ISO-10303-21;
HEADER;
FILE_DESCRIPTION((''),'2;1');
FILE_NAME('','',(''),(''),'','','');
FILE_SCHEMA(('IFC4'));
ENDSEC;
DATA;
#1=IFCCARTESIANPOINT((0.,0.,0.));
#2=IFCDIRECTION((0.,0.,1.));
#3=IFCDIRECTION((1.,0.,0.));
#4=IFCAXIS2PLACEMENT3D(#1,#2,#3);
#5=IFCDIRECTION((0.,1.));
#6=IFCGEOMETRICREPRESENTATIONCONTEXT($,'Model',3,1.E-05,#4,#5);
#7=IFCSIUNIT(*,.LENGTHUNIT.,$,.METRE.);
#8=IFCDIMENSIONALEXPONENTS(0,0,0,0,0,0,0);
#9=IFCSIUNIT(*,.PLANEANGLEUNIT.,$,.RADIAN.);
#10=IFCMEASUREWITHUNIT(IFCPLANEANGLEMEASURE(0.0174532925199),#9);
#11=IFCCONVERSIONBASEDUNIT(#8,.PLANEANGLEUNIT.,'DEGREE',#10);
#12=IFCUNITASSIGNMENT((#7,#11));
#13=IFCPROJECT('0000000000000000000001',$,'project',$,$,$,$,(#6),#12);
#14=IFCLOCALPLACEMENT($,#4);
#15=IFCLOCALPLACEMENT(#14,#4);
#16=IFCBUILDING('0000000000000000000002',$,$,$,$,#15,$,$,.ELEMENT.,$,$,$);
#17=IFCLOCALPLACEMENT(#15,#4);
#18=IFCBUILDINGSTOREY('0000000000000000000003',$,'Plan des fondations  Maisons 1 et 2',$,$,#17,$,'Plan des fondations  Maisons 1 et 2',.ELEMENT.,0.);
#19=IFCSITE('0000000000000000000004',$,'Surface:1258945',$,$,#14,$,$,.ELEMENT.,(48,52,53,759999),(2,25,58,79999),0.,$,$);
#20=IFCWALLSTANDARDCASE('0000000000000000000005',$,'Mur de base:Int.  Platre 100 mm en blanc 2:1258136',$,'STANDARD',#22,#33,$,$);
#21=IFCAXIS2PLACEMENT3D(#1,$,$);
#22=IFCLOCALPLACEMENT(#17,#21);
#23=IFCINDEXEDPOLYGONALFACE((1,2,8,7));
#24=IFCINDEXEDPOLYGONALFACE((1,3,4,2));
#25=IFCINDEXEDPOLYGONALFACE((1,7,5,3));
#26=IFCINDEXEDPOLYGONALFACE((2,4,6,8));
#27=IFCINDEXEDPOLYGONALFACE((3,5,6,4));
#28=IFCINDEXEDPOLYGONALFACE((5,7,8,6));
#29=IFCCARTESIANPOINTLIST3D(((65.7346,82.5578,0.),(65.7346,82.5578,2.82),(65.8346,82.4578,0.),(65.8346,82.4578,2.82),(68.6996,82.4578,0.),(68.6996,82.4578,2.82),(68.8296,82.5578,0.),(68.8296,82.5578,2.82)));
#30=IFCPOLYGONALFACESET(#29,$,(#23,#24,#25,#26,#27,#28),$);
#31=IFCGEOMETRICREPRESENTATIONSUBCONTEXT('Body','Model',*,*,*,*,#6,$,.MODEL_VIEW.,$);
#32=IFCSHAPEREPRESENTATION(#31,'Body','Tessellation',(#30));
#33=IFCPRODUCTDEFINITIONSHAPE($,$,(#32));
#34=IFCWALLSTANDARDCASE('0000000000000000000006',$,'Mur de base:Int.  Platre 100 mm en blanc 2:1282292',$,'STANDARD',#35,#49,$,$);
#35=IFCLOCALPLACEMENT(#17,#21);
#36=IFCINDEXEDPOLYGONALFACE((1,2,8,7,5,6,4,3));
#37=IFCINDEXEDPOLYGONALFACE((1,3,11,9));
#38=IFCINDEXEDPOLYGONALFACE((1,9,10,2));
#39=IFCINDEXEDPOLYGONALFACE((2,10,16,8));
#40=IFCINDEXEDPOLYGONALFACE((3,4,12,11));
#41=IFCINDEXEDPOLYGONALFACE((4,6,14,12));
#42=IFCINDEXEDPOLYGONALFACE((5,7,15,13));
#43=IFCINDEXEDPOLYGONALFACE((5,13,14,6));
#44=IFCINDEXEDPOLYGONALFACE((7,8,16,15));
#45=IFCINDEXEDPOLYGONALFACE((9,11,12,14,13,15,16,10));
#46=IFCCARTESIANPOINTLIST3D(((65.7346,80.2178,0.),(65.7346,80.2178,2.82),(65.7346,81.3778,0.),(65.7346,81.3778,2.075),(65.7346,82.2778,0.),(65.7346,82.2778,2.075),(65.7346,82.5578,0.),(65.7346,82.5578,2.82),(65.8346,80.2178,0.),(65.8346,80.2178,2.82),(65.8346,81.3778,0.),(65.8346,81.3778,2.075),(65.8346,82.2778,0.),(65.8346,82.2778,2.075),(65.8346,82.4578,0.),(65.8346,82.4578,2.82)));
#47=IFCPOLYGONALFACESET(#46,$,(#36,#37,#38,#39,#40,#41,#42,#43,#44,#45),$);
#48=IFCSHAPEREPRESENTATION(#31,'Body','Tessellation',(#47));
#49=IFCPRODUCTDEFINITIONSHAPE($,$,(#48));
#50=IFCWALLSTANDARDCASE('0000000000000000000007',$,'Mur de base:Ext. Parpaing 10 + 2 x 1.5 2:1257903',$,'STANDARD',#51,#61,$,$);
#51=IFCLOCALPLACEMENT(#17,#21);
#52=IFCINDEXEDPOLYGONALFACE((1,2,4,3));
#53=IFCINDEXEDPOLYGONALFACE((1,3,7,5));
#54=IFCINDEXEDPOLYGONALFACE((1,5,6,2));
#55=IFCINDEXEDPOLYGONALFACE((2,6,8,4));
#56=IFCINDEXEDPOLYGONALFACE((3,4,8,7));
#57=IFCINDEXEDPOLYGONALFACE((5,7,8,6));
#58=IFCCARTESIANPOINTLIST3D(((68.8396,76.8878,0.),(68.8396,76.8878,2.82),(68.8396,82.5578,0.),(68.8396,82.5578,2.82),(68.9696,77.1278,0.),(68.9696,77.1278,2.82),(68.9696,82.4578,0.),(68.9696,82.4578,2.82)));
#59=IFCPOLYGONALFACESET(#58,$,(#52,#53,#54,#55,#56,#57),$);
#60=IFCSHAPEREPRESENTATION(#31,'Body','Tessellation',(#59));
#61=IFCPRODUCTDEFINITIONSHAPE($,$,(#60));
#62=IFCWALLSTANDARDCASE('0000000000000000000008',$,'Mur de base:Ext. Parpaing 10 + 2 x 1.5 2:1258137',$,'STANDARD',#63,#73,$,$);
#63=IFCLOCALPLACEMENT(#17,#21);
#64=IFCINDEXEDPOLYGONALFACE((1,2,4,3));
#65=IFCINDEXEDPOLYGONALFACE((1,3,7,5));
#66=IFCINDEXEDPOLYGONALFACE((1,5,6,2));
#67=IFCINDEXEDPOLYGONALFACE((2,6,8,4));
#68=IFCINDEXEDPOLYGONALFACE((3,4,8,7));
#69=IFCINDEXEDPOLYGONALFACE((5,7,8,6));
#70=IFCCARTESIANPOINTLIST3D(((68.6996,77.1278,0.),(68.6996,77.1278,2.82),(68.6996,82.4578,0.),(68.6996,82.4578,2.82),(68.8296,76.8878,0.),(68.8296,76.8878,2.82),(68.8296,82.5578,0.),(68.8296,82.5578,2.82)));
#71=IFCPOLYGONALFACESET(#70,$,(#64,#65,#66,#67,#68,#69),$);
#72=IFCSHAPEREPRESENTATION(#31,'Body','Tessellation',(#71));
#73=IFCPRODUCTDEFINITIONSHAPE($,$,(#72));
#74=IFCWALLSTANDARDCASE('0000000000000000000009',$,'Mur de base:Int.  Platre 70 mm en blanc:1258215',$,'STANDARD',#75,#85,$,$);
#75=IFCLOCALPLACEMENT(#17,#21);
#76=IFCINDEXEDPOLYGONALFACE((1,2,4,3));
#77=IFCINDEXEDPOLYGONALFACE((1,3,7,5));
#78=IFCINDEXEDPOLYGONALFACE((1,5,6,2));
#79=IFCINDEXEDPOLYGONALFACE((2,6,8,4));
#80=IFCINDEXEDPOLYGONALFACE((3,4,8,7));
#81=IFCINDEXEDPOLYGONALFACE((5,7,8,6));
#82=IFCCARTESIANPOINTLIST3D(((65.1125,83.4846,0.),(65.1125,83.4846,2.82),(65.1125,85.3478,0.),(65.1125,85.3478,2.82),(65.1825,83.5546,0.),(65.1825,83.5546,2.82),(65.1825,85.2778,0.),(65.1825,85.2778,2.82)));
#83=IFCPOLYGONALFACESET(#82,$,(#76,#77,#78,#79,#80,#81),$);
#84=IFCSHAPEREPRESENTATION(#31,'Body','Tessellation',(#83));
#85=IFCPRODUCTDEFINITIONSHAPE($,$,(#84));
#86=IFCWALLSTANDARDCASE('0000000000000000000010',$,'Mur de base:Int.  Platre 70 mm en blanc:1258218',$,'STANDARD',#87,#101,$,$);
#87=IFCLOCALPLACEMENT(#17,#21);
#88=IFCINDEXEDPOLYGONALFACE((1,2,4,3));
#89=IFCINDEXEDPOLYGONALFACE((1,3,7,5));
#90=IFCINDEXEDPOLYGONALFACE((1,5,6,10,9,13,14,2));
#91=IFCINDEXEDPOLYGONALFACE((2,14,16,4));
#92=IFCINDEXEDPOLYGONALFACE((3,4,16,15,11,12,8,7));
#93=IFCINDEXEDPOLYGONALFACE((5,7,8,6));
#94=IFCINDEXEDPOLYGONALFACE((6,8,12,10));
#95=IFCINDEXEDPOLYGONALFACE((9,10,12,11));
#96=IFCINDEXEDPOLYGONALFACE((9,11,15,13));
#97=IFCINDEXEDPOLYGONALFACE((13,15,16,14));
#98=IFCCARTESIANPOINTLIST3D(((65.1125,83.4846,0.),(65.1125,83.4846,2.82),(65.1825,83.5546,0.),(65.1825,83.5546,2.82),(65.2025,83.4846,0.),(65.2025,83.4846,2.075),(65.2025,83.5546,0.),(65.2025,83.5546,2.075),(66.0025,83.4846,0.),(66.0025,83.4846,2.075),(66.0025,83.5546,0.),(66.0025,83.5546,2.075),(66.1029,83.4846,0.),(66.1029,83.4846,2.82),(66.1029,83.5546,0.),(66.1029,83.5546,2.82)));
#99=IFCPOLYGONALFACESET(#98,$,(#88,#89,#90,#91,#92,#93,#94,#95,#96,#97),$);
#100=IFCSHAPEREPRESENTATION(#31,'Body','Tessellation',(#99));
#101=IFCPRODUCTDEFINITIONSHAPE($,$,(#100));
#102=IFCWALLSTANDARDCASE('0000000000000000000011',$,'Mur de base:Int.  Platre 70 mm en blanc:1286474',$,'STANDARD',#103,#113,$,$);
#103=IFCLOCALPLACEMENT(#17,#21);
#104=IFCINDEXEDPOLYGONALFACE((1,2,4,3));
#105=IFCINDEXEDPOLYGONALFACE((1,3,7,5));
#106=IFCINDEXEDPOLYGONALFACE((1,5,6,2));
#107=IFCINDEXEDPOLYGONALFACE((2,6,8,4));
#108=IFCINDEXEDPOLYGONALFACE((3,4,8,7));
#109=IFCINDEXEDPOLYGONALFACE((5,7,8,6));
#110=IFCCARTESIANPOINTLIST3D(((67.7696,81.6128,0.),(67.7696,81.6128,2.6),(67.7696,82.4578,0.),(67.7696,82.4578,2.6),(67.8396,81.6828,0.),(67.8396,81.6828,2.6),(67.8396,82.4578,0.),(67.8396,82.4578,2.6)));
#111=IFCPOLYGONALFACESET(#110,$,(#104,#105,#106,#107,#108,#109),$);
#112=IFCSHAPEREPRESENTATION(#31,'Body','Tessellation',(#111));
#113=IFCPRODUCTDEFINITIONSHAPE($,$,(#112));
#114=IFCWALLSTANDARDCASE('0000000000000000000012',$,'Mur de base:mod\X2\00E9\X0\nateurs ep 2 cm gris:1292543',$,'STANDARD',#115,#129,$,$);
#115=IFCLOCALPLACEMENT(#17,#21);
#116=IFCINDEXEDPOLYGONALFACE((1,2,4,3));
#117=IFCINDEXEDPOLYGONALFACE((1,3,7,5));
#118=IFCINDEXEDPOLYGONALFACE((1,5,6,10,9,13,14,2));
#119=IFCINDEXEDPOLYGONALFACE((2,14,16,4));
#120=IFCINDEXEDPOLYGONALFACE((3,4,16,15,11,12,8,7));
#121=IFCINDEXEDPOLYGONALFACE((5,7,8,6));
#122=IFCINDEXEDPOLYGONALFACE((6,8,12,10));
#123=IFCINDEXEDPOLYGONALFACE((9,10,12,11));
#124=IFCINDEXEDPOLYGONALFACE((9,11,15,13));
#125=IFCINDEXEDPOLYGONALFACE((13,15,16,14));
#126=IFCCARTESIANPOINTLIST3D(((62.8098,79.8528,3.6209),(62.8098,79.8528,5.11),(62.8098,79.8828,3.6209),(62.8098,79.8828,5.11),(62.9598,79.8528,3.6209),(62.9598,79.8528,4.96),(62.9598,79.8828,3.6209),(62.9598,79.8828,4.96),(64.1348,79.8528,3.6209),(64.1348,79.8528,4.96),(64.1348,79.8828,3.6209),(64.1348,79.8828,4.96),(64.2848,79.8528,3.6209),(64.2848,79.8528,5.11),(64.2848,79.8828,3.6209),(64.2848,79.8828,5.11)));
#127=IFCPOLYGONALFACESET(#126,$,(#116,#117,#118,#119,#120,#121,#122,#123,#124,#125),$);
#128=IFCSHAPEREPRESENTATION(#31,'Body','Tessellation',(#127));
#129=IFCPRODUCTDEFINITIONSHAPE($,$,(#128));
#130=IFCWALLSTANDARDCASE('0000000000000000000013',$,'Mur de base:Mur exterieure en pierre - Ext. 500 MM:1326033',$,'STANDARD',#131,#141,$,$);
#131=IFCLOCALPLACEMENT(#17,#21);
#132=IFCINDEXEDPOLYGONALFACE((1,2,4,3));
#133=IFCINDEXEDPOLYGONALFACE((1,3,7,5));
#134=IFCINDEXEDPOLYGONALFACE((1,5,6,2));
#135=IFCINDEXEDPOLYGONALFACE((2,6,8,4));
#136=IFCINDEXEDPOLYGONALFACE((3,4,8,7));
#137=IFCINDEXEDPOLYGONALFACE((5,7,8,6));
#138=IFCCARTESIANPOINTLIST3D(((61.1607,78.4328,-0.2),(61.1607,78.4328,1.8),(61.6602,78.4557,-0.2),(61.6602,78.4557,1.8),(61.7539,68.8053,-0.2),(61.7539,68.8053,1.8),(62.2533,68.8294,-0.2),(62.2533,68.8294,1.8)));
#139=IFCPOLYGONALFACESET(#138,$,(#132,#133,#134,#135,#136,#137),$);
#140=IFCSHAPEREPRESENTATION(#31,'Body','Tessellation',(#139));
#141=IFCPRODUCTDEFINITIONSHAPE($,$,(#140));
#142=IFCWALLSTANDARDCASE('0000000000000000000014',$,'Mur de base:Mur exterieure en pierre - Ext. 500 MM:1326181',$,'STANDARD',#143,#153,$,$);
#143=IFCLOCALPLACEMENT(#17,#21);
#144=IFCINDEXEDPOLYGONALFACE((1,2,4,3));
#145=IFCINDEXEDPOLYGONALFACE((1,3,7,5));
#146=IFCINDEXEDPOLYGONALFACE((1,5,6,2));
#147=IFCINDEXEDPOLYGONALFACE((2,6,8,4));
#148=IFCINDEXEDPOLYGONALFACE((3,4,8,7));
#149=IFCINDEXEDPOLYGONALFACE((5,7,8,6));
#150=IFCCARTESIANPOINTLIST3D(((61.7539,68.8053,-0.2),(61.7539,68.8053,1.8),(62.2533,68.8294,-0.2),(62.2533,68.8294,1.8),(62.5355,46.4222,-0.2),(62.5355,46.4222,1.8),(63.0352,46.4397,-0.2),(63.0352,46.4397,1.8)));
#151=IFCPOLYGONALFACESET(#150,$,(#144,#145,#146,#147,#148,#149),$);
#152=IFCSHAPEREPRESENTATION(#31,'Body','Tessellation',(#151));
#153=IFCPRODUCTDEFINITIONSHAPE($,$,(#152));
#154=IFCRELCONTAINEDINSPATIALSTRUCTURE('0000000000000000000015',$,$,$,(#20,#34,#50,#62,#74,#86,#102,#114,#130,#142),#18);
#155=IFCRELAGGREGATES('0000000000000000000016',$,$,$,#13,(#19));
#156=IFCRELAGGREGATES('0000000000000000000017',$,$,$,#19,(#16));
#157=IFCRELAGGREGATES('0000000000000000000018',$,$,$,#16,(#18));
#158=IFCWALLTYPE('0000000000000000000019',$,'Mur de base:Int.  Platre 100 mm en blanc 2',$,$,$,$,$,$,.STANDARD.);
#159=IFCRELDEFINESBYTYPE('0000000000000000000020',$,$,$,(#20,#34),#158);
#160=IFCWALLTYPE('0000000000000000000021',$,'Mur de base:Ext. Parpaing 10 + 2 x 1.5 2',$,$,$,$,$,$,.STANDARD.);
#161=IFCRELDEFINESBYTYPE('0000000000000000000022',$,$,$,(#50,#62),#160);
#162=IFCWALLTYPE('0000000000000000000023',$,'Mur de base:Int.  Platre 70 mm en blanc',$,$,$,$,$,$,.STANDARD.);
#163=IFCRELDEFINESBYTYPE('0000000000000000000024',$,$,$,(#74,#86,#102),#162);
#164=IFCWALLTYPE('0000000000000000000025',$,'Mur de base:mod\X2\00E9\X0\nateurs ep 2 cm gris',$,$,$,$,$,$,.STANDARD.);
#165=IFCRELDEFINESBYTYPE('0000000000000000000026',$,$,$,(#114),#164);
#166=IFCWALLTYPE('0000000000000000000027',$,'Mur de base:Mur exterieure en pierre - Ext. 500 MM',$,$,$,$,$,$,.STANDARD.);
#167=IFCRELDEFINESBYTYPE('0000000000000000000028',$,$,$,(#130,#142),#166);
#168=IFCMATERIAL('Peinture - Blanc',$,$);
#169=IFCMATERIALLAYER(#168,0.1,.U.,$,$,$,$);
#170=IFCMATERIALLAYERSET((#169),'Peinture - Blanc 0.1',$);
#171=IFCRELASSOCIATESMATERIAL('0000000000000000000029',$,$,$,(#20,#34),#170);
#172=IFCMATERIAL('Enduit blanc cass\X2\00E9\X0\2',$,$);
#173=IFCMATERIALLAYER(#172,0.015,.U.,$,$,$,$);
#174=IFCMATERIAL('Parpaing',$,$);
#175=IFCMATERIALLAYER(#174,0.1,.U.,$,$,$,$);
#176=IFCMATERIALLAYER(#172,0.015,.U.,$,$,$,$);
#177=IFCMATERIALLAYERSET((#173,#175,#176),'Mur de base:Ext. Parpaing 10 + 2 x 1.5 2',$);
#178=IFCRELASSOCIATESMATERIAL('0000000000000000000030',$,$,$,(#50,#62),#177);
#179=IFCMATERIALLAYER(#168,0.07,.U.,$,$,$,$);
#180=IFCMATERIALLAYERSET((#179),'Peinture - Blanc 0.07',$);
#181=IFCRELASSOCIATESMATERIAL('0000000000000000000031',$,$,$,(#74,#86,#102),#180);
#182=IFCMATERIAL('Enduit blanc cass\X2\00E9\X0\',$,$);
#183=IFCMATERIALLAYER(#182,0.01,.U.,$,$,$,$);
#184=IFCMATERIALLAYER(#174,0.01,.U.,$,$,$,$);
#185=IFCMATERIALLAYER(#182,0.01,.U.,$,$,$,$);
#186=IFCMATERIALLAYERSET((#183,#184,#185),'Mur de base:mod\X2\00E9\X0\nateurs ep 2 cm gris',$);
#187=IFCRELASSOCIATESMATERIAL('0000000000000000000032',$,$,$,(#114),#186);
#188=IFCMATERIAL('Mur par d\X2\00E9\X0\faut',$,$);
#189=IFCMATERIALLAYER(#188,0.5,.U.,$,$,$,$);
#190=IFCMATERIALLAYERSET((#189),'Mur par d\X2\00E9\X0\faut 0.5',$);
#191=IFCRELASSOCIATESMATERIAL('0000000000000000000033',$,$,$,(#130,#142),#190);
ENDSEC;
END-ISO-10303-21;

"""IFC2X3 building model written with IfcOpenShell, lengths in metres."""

from ifc_helpers import new_model, entity, si_unit, converted_unit, direction, frame, origin_with_axes, origin_2d_with_axis, place, context, subcontext, project, spatial, polyline, rectangle, outline, extrude, clip, halfspace, material, layer, layer_set, layer_usage, type_object, element, save


model = new_model("IFC2X3")

# Units and contexts
model_context = context("Model", 3, precision=1e-05, world=origin_with_axes(), true_north=direction((0.0, 1.0)))
body_context = subcontext(model_context, "Body", "Model", "MODEL_VIEW")
ifc_project = project(units=[si_unit("LENGTHUNIT", "METRE"), converted_unit("PLANEANGLEUNIT", "DEGREE", entity("IfcPlaneAngleMeasure", 0.0174532925199), si_unit("PLANEANGLEUNIT", "RADIAN"), dimensions=[0, 0, 0, 0, 0, 0, 0])], contexts=[model_context])

# Site, building, storey
site_placement = place(None, origin_with_axes())
site = spatial("IfcSite", under=ifc_project, at=site_placement, Name="Surface:1258945", CompositionType="ELEMENT", RefLatitude=(48, 52, 53, 759999), RefLongitude=(2, 25, 58, 79999), RefElevation=0.0)
building_placement = place(site_placement, origin_with_axes())
building = spatial("IfcBuilding", under=site, at=building_placement, CompositionType="ELEMENT")
storey_placement = place(building_placement, origin_with_axes())
storey = spatial("IfcBuildingStorey", under=building, at=storey_placement, Name="Plan des fondations  Maisons 1 et 2", LongName="Plan des fondations  Maisons 1 et 2", CompositionType="ELEMENT", Elevation=0.0)

# Shared definitions
ifc_material_1 = material(Name="Parpaing")
ifc_material_2 = material(Name="Enduit blanc cassé2")

# Wall
ifc_material_3 = material(Name="Peinture - Blanc")
ifc_layer_1 = layer(ifc_material_3, 0.1, ventilated="UNKNOWN")
ifc_layer_set_1 = layer_set([ifc_layer_1], Name="Peinture - Blanc 0.1")
ifc_layer_usage_1 = layer_usage(ifc_layer_set_1, "AXIS2", "POSITIVE", -0.05)
wall_type_1 = type_object("IfcWallType", Name="Mur de base:Int.  Platre 100 mm en blanc 2", PredefinedType="STANDARD")
wall_1_placement = place(storey_placement, frame((65.7846, 82.5078, 0.0), z_axis=(0.0, 0.0, 1.0), x_axis=(1.0, 0.0, 0.0)))
element("IfcWallStandardCase", 1, at=wall_1_placement, inside=storey, type_object=wall_type_1, material=ifc_layer_usage_1, Name="Mur de base:Int.  Platre 100 mm en blanc 2:1258136", ObjectType="STANDARD", context=body_context, shape_type="SweptSolid", body=[
    extrude(outline(polyline([(0.05, -0.05), (2.915, -0.05), (3.045, 0.05), (-0.05, 0.05), (0.05, -0.05)])), origin_with_axes(), (0.0, 0.0, 1.0), 2.82),
])

# Wall, opening
ifc_layer_usage_2 = layer_usage(ifc_layer_set_1, "AXIS2", "POSITIVE", -0.05)
wall_2_placement = place(storey_placement, frame((65.7846, 80.2178, 0.0), z_axis=(0.0, 0.0, 1.0), x_axis=(0.0, 1.0, 0.0)))
wall_2 = element("IfcWallStandardCase", 2, at=wall_2_placement, inside=storey, type_object=wall_type_1, material=ifc_layer_usage_2, Name="Mur de base:Int.  Platre 100 mm en blanc 2:1282292", ObjectType="STANDARD", context=body_context, shape_type="SweptSolid", body=[
    extrude(outline(polyline([(0.0, -0.05), (2.24, -0.05), (2.34, 0.05), (0.0, 0.05), (0.0, -0.05)])), origin_with_axes(), (0.0, 0.0, 1.0), 2.82),
])
opening_1_placement = place(wall_2_placement, frame((1.61, 0.0, 0.0), z_axis=(0.0, 0.0, 1.0), x_axis=(1.0, 0.0, 0.0)))
element("IfcOpeningElement", 3, at=opening_1_placement, cuts=wall_2, context=body_context, shape_type="SweptSolid", body=[
    extrude(outline(polyline([(-0.45, 0.0), (0.45, 0.0), (0.45, 2.075), (-0.45, 2.075), (-0.45, 0.0)])), frame((0.0, 0.05, 0.0), z_axis=(0.0, 1.0, 0.0), x_axis=(-1.0, 0.0, 0.0)), (0.0, 0.0, -1.0), 0.1),
])

# Walls
ifc_layer_2 = layer(ifc_material_2, 0.015, ventilated="UNKNOWN")
ifc_layer_3 = layer(ifc_material_1, 0.1, ventilated="UNKNOWN")
ifc_layer_4 = layer(ifc_material_2, 0.015, ventilated="UNKNOWN")
ifc_layer_set_2 = layer_set([ifc_layer_2, ifc_layer_3, ifc_layer_4], Name="Mur de base:Ext. Parpaing 10 + 2 x 1.5 2")
ifc_layer_usage_3 = layer_usage(ifc_layer_set_2, "AXIS2", "POSITIVE", -0.065)
wall_type_2 = type_object("IfcWallType", Name="Mur de base:Ext. Parpaing 10 + 2 x 1.5 2", PredefinedType="STANDARD")
wall_3_placement = place(storey_placement, frame((68.9046, 82.5078, 0.0), z_axis=(0.0, 0.0, 1.0), x_axis=(0.0, -1.0, 0.0)))
element("IfcWallStandardCase", 4, at=wall_3_placement, inside=storey, type_object=wall_type_2, material=ifc_layer_usage_3, Name="Mur de base:Ext. Parpaing 10 + 2 x 1.5 2:1257903", ObjectType="STANDARD", context=body_context, shape_type="SweptSolid", body=[
    extrude(outline(polyline([(-0.05, -0.065), (5.62, -0.065), (5.38, 0.065), (0.05, 0.065), (-0.05, -0.065)])), origin_with_axes(), (0.0, 0.0, 1.0), 2.82),
])
ifc_layer_usage_4 = layer_usage(ifc_layer_set_2, "AXIS2", "POSITIVE", -0.065)
wall_4_placement = place(storey_placement, frame((68.7646, 82.5078, 0.0), z_axis=(0.0, 0.0, 1.0), x_axis=(0.0, -1.0, 0.0)))
element("IfcWallStandardCase", 5, at=wall_4_placement, inside=storey, type_object=wall_type_2, material=ifc_layer_usage_4, Name="Mur de base:Ext. Parpaing 10 + 2 x 1.5 2:1258137", ObjectType="STANDARD", context=body_context, shape_type="SweptSolid", body=[
    extrude(outline(polyline([(0.05, -0.065), (5.38, -0.065), (5.62, 0.065), (-0.05, 0.065), (0.05, -0.065)])), origin_with_axes(), (0.0, 0.0, 1.0), 2.82),
])
ifc_layer_5 = layer(ifc_material_3, 0.07, ventilated="UNKNOWN")
ifc_layer_set_3 = layer_set([ifc_layer_5], Name="Peinture - Blanc 0.07")
ifc_layer_usage_5 = layer_usage(ifc_layer_set_3, "AXIS2", "POSITIVE", -0.035)
wall_type_3 = type_object("IfcWallType", Name="Mur de base:Int.  Platre 70 mm en blanc", PredefinedType="STANDARD")
wall_5_placement = place(storey_placement, frame((65.1475, 83.5196, 0.0), z_axis=(0.0, 0.0, 1.0), x_axis=(0.0, 1.0, 0.0)))
element("IfcWallStandardCase", 6, at=wall_5_placement, inside=storey, type_object=wall_type_3, material=ifc_layer_usage_5, Name="Mur de base:Int.  Platre 70 mm en blanc:1258215", ObjectType="STANDARD", context=body_context, shape_type="SweptSolid", body=[
    extrude(outline(polyline([(0.035, -0.035), (1.7581, -0.035), (1.8281, 0.035), (-0.035, 0.035), (0.035, -0.035)])), origin_with_axes(), (0.0, 0.0, 1.0), 2.82),
])

# Wall, opening
ifc_layer_usage_6 = layer_usage(ifc_layer_set_3, "AXIS2", "POSITIVE", -0.035)
wall_6_placement = place(storey_placement, frame((66.1029, 83.5196, 0.0), z_axis=(0.0, 0.0, 1.0), x_axis=(-1.0, 0.0, 0.0)))
wall_6 = element("IfcWallStandardCase", 7, at=wall_6_placement, inside=storey, type_object=wall_type_3, material=ifc_layer_usage_6, Name="Mur de base:Int.  Platre 70 mm en blanc:1258218", ObjectType="STANDARD", context=body_context, shape_type="SweptSolid", body=[
    extrude(outline(polyline([(0.0, -0.035), (0.9204, -0.035), (0.9904, 0.035), (0.0, 0.035), (0.0, -0.035)])), origin_with_axes(), (0.0, 0.0, 1.0), 2.82),
])
opening_2_placement = place(wall_6_placement, frame((0.5004, 0.0, 0.0), z_axis=(0.0, 0.0, 1.0), x_axis=(1.0, 0.0, 0.0)))
element("IfcOpeningElement", 8, at=opening_2_placement, cuts=wall_6, context=body_context, shape_type="SweptSolid", body=[
    extrude(outline(polyline([(0.4, 0.0), (0.4, 2.075), (-0.4, 2.075), (-0.4, 0.0), (0.4, 0.0)])), frame((0.0, -0.035, 0.0), z_axis=(0.0, 1.0, 0.0), x_axis=(-1.0, 0.0, 0.0)), (0.0, 0.0, 1.0), 0.07),
])

# Wall
ifc_layer_usage_7 = layer_usage(ifc_layer_set_3, "AXIS2", "POSITIVE", -0.035)
wall_7_placement = place(storey_placement, frame((67.8046, 81.6478, 0.0), z_axis=(0.0, 0.0, 1.0), x_axis=(0.0, 1.0, 0.0)))
element("IfcWallStandardCase", 9, at=wall_7_placement, inside=storey, type_object=wall_type_3, material=ifc_layer_usage_7, Name="Mur de base:Int.  Platre 70 mm en blanc:1286474", ObjectType="STANDARD", context=body_context, shape_type="SweptSolid", body=[
    extrude(outline(polyline([(0.035, -0.035), (0.81, -0.035), (0.81, 0.035), (-0.035, 0.035), (0.035, -0.035)])), origin_with_axes(), (0.0, 0.0, 1.0), 2.6),
])

# Wall, opening
ifc_material_4 = material(Name="Enduit blanc cassé")
ifc_layer_6 = layer(ifc_material_4, 0.01, ventilated="UNKNOWN")
ifc_layer_7 = layer(ifc_material_1, 0.01, ventilated="UNKNOWN")
ifc_layer_8 = layer(ifc_material_4, 0.01, ventilated="UNKNOWN")
ifc_layer_set_4 = layer_set([ifc_layer_6, ifc_layer_7, ifc_layer_8], Name="Mur de base:modénateurs ep 2 cm gris")
wall_type_4 = type_object("IfcWallType", Name="Mur de base:modénateurs ep 2 cm gris", PredefinedType="STANDARD")
ifc_layer_usage_8 = layer_usage(ifc_layer_set_4, "AXIS2", "POSITIVE", -0.015)
wall_8_placement = place(storey_placement, frame((64.2848, 79.8678, 3.6209), z_axis=(0.0, 0.0, 1.0), x_axis=(-1.0, 0.0, 0.0)))
wall_8 = element("IfcWallStandardCase", 10, at=wall_8_placement, inside=storey, type_object=wall_type_4, material=ifc_layer_usage_8, Name="Mur de base:modénateurs ep 2 cm gris:1292543", ObjectType="STANDARD", context=body_context, shape_type="Clipping", body=[
    clip(extrude(outline(polyline([(0.0, -0.015), (1.475, -0.015), (1.475, 0.015), (0.0, 0.015), (0.0, -0.015)])), origin_with_axes(), (0.0, 0.0, 1.0), 1.4891), halfspace(frame((0.0, 0.0, 0.0), z_axis=(0.0, 0.0, 1.0), x_axis=(0.0, -1.0, 0.0)), True)),
])
opening_3_placement = place(wall_8_placement, frame((64.2848, 79.8678, -3.6209), z_axis=(0.0, 0.0, 1.0), x_axis=(-1.0, 0.0, 0.0)))
element("IfcOpeningElement", 11, at=opening_3_placement, cuts=wall_8, context=body_context, shape_type="SweptSolid", body=[
    extrude(rectangle(XDim=1.3391, YDim=1.175, at=origin_2d_with_axis()), frame((63.5473, 79.8528, 4.2904), z_axis=(0.0, 1.0, 0.0), x_axis=(0.0, 0.0, 1.0)), (0.0, 0.0, 1.0), 0.03),
])

# Walls
ifc_material_5 = material(Name="Mur par défaut")
ifc_layer_9 = layer(ifc_material_5, 0.5, ventilated="UNKNOWN")
ifc_layer_set_5 = layer_set([ifc_layer_9], Name="Mur par défaut 0.5")
ifc_layer_usage_9 = layer_usage(ifc_layer_set_5, "AXIS2", "POSITIVE", -0.25)
wall_type_5 = type_object("IfcWallType", Name="Mur de base:Mur exterieure en pierre - Ext. 500 MM", PredefinedType="STANDARD")
wall_9_placement = place(storey_placement, frame((61.4105, 78.4442, -0.2), z_axis=(0.0, 0.0, 1.0), x_axis=(0.061496, -0.998107, 0.0)))
element("IfcWallStandardCase", 12, at=wall_9_placement, inside=storey, type_object=wall_type_5, material=ifc_layer_usage_9, Name="Mur de base:Mur exterieure en pierre - Ext. 500 MM:1326033", ObjectType="STANDARD", context=body_context, shape_type="SweptSolid", body=[
    extrude(outline(polyline([(-0.0039, -0.25), (9.6418, -0.25), (9.6485, 0.25), (0.0039, 0.25), (-0.0039, -0.25)])), origin_with_axes(), (0.0, 0.0, 1.0), 2.0),
])
ifc_layer_usage_10 = layer_usage(ifc_layer_set_5, "AXIS2", "POSITIVE", -0.25)
wall_10_placement = place(storey_placement, frame((62.0036, 68.8173, -0.2), z_axis=(0.0, 0.0, 1.0), x_axis=(0.034899, -0.999391, 0.0)))
element("IfcWallStandardCase", 13, at=wall_10_placement, inside=storey, type_object=wall_type_5, material=ifc_layer_usage_10, Name="Mur de base:Mur exterieure en pierre - Ext. 500 MM:1326181", ObjectType="STANDARD", context=body_context, shape_type="SweptSolid", body=[
    extrude(outline(polyline([(0.0033, -0.25), (22.4, -0.25), (22.4, 0.25), (-0.0033, 0.25), (0.0033, -0.25)])), origin_with_axes(), (0.0, 0.0, 1.0), 2.0),
])

save(model, "model.ifc")
